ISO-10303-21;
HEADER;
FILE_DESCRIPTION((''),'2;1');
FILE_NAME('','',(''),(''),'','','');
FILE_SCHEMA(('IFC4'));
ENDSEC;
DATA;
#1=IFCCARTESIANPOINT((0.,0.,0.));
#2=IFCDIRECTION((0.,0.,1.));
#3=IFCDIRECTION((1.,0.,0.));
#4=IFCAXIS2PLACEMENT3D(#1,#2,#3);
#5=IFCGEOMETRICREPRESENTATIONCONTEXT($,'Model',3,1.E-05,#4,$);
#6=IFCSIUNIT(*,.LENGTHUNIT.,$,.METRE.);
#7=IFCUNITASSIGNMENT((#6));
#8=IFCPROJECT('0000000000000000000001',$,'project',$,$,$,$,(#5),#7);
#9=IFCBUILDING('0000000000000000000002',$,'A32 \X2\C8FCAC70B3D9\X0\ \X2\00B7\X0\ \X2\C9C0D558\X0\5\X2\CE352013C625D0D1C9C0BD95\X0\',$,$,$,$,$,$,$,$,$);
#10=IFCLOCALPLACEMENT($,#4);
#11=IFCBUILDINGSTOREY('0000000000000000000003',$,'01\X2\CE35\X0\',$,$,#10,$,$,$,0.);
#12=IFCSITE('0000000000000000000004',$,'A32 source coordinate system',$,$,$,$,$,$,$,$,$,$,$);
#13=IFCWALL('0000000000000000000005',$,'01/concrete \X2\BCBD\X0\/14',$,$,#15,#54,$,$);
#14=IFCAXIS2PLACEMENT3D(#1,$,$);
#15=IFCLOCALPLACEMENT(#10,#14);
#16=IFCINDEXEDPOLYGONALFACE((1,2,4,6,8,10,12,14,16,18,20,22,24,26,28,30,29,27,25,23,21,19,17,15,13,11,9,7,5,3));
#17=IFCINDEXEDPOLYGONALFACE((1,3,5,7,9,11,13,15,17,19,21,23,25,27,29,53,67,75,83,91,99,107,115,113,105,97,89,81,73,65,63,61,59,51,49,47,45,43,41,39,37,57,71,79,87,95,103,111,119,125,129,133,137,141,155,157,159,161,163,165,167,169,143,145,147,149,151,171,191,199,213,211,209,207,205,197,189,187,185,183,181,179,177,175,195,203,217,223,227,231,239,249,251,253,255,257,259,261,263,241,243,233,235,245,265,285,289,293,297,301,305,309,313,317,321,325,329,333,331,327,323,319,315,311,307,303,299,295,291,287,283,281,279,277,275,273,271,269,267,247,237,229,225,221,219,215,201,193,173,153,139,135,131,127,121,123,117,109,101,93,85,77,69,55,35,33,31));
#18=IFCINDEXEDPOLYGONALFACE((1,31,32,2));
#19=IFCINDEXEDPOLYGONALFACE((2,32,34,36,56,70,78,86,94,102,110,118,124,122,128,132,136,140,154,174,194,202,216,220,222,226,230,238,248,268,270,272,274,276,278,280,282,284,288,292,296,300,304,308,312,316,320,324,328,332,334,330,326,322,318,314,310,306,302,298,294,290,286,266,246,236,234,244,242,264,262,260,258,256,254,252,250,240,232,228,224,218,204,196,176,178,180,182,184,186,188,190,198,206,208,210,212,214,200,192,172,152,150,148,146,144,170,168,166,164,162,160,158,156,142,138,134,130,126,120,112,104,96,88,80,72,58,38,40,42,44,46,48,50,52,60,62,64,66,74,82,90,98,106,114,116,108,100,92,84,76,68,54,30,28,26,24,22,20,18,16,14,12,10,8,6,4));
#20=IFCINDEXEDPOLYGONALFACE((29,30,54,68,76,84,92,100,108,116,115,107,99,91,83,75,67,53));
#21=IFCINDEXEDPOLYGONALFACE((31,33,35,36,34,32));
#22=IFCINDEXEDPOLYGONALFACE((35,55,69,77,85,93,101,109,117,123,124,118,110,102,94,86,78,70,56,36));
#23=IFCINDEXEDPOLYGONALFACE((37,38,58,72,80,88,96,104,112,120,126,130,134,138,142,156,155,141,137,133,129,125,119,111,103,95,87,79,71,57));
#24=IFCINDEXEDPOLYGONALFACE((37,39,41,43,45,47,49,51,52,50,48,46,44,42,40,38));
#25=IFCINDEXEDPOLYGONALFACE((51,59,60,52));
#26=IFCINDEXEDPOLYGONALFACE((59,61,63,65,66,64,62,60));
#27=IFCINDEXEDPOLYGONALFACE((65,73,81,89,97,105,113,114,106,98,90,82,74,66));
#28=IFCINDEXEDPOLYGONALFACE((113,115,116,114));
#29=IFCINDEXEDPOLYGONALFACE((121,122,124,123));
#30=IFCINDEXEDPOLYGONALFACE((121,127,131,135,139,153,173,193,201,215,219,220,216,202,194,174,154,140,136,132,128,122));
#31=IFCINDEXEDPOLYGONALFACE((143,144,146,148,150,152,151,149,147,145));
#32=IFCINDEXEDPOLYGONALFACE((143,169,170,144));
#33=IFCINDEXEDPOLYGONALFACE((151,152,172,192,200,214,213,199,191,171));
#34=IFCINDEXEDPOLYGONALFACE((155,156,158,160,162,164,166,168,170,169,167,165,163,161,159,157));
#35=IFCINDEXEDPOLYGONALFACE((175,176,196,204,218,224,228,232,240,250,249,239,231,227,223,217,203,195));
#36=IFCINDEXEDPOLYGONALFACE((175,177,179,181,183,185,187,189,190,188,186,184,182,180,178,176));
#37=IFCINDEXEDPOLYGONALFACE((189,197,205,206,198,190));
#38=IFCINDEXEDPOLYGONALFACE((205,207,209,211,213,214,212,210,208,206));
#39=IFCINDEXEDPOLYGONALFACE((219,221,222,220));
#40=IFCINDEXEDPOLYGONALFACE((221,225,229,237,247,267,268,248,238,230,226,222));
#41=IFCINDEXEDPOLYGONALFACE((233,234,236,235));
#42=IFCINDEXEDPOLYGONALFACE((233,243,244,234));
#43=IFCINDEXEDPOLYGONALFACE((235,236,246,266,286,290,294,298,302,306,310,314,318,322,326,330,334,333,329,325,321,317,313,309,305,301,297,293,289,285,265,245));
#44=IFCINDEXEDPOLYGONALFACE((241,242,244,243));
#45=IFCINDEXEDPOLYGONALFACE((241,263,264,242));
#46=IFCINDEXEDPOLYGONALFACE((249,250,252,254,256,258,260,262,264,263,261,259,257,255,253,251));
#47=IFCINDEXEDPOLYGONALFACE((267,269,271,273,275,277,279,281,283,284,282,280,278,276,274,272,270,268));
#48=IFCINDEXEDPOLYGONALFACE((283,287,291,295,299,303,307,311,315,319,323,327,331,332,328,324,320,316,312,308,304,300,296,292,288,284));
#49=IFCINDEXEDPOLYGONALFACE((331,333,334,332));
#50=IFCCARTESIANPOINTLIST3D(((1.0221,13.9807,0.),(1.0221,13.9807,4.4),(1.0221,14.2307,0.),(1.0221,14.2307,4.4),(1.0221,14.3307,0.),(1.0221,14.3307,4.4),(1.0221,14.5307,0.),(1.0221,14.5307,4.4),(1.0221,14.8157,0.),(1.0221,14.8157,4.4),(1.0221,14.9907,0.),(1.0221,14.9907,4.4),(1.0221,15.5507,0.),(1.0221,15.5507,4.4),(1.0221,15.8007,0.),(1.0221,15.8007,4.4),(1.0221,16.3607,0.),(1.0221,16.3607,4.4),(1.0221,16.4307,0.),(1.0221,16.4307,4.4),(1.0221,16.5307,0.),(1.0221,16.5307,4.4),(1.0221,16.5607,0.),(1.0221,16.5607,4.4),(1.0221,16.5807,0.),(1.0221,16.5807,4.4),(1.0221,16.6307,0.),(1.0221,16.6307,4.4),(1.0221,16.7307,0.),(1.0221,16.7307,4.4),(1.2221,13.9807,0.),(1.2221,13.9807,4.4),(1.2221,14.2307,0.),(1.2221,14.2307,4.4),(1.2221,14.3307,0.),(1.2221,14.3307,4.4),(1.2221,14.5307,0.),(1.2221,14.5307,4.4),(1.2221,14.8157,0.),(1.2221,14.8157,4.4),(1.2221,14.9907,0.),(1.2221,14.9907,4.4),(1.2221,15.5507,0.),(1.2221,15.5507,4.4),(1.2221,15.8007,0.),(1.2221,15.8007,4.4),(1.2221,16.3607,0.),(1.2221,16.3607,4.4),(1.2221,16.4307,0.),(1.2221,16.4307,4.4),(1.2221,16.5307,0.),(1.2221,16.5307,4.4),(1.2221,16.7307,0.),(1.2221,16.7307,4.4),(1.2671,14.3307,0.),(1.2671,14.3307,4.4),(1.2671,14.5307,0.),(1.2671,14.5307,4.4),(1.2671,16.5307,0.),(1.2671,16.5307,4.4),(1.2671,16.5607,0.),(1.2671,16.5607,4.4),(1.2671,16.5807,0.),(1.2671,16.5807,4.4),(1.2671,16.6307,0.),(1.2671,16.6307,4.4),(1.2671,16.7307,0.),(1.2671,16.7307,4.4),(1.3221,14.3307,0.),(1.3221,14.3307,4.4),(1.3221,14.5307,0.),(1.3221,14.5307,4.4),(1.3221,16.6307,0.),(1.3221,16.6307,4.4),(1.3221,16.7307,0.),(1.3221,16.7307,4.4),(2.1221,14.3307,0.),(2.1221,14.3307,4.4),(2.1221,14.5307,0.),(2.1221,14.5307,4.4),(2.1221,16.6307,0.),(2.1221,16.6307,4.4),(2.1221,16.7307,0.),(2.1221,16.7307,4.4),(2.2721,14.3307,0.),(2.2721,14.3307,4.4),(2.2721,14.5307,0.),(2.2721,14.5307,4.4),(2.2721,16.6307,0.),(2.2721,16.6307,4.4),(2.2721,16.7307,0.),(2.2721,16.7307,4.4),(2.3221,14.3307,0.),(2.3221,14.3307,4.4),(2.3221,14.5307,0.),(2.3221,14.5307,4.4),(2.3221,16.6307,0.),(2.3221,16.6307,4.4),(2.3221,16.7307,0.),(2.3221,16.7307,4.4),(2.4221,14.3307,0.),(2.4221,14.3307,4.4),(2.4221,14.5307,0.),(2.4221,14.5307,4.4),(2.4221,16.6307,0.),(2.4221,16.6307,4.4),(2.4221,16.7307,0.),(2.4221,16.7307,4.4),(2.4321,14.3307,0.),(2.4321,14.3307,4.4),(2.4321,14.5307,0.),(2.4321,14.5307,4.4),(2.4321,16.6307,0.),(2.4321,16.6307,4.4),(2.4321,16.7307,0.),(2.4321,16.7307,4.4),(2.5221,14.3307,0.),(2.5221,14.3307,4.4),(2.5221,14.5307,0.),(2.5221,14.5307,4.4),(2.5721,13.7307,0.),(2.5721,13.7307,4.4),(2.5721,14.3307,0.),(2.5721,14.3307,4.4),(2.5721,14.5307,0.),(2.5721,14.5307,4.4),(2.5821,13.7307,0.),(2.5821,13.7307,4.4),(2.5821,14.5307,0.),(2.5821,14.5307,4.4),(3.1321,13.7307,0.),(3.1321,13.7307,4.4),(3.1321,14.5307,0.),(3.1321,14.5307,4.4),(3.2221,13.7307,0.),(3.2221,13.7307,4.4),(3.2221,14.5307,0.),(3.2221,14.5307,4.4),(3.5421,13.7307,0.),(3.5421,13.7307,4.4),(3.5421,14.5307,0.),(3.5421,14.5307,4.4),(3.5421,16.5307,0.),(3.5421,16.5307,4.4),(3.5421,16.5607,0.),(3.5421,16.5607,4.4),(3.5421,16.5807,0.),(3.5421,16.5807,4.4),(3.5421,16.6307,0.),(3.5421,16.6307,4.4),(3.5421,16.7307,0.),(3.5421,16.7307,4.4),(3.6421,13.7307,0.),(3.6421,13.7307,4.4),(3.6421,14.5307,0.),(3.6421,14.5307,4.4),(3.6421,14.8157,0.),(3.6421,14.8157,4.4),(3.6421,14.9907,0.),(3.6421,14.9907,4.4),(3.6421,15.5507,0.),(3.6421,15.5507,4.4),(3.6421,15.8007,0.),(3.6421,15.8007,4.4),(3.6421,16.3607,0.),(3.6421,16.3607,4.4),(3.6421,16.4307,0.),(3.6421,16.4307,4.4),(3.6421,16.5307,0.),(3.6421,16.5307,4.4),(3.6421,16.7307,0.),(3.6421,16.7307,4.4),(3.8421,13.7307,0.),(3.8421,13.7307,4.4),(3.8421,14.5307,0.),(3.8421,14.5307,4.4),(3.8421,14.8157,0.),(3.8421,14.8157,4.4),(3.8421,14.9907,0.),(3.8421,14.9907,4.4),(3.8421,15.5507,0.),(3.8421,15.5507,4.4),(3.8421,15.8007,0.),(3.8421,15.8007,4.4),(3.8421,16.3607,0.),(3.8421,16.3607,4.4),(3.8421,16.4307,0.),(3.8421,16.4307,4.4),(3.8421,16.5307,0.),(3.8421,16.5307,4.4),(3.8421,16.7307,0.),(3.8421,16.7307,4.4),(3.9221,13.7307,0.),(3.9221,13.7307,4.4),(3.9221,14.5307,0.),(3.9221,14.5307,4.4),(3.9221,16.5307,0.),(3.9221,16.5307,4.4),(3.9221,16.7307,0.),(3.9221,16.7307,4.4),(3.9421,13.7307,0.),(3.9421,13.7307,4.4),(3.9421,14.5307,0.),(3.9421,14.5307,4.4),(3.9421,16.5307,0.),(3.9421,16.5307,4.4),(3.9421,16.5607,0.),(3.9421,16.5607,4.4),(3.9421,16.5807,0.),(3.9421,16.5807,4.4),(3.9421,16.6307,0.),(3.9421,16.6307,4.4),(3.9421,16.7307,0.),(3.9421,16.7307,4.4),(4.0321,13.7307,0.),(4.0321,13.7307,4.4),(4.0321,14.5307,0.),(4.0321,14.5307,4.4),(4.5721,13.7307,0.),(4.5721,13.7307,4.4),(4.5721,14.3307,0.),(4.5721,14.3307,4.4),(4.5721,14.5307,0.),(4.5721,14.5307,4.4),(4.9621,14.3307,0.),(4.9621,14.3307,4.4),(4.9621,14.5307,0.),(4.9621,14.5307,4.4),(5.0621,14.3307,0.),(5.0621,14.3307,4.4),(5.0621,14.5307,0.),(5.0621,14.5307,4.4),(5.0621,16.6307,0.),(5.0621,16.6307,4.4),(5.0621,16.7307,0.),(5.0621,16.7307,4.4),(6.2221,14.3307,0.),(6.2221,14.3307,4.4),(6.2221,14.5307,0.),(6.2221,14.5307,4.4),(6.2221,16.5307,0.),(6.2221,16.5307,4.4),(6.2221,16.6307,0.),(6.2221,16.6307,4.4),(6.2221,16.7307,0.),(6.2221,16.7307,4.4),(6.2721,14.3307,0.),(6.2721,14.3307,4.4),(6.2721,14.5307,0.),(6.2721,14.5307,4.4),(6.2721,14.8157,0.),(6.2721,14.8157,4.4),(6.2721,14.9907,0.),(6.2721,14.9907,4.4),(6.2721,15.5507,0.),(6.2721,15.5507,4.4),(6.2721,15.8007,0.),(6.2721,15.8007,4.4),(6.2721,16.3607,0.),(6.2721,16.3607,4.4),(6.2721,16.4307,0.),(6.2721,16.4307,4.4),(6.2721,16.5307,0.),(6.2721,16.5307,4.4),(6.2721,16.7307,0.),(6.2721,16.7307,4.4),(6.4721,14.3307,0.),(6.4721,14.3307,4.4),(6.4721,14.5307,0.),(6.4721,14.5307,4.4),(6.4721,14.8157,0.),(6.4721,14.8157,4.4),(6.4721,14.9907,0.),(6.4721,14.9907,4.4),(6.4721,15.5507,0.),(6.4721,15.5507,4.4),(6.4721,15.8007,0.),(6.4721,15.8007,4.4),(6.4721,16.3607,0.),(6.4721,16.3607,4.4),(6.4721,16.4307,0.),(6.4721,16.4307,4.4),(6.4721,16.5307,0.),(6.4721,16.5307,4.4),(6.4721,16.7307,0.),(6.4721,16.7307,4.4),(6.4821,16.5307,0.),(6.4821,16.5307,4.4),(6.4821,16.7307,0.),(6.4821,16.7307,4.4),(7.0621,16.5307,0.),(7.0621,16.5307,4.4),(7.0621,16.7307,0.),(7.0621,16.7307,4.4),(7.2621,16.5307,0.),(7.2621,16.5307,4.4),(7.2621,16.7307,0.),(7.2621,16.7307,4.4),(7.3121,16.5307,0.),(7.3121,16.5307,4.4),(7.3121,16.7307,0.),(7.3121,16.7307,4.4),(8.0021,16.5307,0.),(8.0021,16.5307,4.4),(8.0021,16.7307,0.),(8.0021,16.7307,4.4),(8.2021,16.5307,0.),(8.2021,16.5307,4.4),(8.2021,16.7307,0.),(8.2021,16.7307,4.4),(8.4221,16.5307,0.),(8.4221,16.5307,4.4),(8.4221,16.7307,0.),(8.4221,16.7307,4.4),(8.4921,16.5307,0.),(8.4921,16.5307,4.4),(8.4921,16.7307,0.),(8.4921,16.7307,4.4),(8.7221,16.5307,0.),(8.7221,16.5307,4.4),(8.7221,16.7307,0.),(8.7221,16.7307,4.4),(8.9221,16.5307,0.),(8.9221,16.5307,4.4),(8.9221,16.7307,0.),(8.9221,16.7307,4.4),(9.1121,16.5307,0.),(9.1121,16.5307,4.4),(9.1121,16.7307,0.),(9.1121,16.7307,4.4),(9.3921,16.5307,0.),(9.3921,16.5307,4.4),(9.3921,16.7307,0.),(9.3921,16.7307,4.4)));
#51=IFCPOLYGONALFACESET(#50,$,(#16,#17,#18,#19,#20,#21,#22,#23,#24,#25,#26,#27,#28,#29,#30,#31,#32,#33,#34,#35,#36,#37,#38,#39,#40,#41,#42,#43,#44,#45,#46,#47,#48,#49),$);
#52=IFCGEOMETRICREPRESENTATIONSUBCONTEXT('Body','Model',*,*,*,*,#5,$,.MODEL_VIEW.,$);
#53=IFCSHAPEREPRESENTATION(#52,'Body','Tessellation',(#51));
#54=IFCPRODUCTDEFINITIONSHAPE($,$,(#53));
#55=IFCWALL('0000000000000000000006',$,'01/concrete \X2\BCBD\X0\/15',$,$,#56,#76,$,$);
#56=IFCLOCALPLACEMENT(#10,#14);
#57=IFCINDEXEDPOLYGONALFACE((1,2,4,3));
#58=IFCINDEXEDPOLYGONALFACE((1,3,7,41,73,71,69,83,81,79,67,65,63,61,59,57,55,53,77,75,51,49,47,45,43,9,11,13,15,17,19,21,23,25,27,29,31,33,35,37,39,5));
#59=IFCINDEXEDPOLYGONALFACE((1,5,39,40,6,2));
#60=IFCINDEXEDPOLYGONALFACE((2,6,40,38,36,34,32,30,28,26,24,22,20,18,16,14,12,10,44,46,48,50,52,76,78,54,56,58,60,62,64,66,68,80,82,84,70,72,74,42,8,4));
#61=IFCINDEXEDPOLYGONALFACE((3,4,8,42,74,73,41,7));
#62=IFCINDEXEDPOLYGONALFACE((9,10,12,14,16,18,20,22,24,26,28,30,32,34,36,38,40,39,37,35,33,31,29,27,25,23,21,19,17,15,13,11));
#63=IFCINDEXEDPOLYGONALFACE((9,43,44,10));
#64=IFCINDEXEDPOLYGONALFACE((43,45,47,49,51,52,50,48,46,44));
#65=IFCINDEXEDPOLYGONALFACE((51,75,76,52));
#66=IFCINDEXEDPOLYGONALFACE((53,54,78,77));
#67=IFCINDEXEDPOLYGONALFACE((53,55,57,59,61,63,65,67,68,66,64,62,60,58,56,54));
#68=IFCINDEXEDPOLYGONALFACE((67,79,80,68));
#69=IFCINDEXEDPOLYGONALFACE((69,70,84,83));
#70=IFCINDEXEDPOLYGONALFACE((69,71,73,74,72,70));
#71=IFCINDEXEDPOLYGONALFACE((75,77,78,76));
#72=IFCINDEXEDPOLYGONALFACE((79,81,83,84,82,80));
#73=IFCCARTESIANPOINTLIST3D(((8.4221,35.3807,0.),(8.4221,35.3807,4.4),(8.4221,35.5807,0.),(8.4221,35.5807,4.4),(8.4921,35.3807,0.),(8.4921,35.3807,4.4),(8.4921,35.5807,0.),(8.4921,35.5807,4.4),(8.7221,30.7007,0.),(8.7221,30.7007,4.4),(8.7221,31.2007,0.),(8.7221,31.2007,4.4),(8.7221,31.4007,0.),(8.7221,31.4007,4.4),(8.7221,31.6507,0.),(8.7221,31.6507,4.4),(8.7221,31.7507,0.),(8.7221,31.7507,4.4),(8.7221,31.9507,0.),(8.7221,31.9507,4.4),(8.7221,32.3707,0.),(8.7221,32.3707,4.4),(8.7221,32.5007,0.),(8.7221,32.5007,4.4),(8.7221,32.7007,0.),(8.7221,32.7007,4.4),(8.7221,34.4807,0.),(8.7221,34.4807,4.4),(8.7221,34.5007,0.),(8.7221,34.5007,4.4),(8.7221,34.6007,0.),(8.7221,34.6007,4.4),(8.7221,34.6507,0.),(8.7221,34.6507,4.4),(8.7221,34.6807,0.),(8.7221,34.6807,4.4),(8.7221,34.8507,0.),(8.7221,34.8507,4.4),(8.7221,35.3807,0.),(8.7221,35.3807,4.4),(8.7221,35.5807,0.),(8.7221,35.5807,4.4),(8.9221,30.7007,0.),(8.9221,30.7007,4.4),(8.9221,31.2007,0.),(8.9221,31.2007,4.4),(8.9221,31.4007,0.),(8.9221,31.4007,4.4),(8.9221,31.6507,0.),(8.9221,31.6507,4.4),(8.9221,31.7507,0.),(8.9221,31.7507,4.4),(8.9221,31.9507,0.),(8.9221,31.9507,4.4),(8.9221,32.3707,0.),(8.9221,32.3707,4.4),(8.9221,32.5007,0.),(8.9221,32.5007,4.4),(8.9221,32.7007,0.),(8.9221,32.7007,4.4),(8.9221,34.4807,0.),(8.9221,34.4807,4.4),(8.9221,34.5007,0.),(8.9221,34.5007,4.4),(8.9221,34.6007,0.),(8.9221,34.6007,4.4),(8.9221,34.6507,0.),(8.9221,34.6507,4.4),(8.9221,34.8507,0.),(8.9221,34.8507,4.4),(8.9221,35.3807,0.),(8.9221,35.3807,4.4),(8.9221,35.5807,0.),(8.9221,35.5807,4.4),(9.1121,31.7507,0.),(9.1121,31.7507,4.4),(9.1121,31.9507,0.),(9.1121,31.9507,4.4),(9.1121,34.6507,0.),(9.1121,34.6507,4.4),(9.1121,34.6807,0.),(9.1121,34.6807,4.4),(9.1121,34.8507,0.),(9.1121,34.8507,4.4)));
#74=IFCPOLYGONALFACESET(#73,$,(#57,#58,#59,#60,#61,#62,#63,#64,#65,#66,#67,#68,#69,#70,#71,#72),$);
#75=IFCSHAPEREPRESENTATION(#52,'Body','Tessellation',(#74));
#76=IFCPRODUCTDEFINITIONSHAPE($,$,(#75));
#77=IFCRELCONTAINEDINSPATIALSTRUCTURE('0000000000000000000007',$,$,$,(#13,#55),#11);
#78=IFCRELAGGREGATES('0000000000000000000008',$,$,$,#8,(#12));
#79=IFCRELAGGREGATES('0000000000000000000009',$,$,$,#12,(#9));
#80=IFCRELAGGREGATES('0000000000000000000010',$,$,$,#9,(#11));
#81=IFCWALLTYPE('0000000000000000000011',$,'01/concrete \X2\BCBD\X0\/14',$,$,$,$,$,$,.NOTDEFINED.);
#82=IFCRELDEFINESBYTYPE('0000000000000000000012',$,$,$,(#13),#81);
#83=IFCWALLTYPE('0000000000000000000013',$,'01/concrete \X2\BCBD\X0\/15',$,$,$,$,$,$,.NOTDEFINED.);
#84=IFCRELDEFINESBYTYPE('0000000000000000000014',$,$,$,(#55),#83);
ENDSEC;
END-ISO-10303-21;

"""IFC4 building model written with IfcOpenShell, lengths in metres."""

from ifc_helpers import new_model, si_unit, origin, origin_with_axes, place, context, subcontext, project, spatial, polyline, outline, extrude, source, transform, mapped, type_object, type_shapes, element, save


model = new_model("IFC4")

# Units and contexts
model_context = context("Model", 3, precision=1e-05, world=origin_with_axes())
body_context = subcontext(model_context, "Body", "Model", "MODEL_VIEW")
ifc_project = project(units=[si_unit("LENGTHUNIT", "METRE")], contexts=[model_context])

# Site, building, storey
site = spatial("IfcSite", under=ifc_project, Name="A32 source coordinate system")
building = spatial("IfcBuilding", under=site, Name="A32 주거동 · 지하5층–옥탑지붕")
storey_placement = place(None, origin_with_axes())
storey = spatial("IfcBuildingStorey", under=building, at=storey_placement, Name="01층", Elevation=0.0)

# Walls
wall_type_1 = type_object("IfcWallType", Name="01/concrete 벽/14", PredefinedType="NOTDEFINED")
shared_shape_1 = source(origin(), body_context, "Body", "SweptSolid", [
    extrude(outline(polyline([(1.0221, 14.9907), (1.0221, 15.5507), (1.0221, 15.8007), (1.0221, 16.3607), (1.0221, 16.4307), (1.0221, 16.5307), (1.0221, 16.5607), (1.0221, 16.5807), (1.0221, 16.6307), (1.0221, 16.7307), (1.2221, 16.7307), (1.2671, 16.7307), (1.3221, 16.7307), (2.1221, 16.7307), (2.2721, 16.7307), (2.3221, 16.7307), (2.4221, 16.7307), (2.4321, 16.7307), (2.4321, 16.6307), (2.4221, 16.6307), (2.3221, 16.6307), (2.2721, 16.6307), (2.1221, 16.6307), (1.3221, 16.6307), (1.2671, 16.6307), (1.2671, 16.5807), (1.2671, 16.5607), (1.2671, 16.5307), (1.2221, 16.5307), (1.2221, 16.4307), (1.2221, 16.3607), (1.2221, 15.8007), (1.2221, 15.5507), (1.2221, 14.9907), (1.2221, 14.8157), (1.2221, 14.5307), (1.2671, 14.5307), (1.3221, 14.5307), (2.1221, 14.5307), (2.2721, 14.5307), (2.3221, 14.5307), (2.4221, 14.5307), (2.4321, 14.5307), (2.5221, 14.5307), (2.5721, 14.5307), (2.5821, 14.5307), (3.1321, 14.5307), (3.2221, 14.5307), (3.5421, 14.5307), (3.6421, 14.5307), (3.6421, 14.8157), (3.6421, 14.9907), (3.6421, 15.5507), (3.6421, 15.8007), (3.6421, 16.3607), (3.6421, 16.4307), (3.6421, 16.5307), (3.5421, 16.5307), (3.5421, 16.5607), (3.5421, 16.5807), (3.5421, 16.6307), (3.5421, 16.7307), (3.6421, 16.7307), (3.8421, 16.7307), (3.9221, 16.7307), (3.9421, 16.7307), (3.9421, 16.6307), (3.9421, 16.5807), (3.9421, 16.5607), (3.9421, 16.5307), (3.9221, 16.5307), (3.8421, 16.5307), (3.8421, 16.4307), (3.8421, 16.3607), (3.8421, 15.8007), (3.8421, 15.5507), (3.8421, 14.9907), (3.8421, 14.8157), (3.8421, 14.5307), (3.9221, 14.5307), (3.9421, 14.5307), (4.0321, 14.5307), (4.5721, 14.5307), (4.9621, 14.5307), (5.0621, 14.5307), (6.2221, 14.5307), (6.2721, 14.5307), (6.2721, 14.8157), (6.2721, 14.9907), (6.2721, 15.5507), (6.2721, 15.8007), (6.2721, 16.3607), (6.2721, 16.4307), (6.2721, 16.5307), (6.2221, 16.5307), (6.2221, 16.6307), (5.0621, 16.6307), (5.0621, 16.7307), (6.2221, 16.7307), (6.2721, 16.7307), (6.4721, 16.7307), (6.4821, 16.7307), (7.0621, 16.7307), (7.2621, 16.7307), (7.3121, 16.7307), (8.0021, 16.7307), (8.2021, 16.7307), (8.4221, 16.7307), (8.4921, 16.7307), (8.7221, 16.7307), (8.9221, 16.7307), (9.1121, 16.7307), (9.3921, 16.7307), (9.3921, 16.5307), (9.1121, 16.5307), (8.9221, 16.5307), (8.7221, 16.5307), (8.4921, 16.5307), (8.4221, 16.5307), (8.2021, 16.5307), (8.0021, 16.5307), (7.3121, 16.5307), (7.2621, 16.5307), (7.0621, 16.5307), (6.4821, 16.5307), (6.4721, 16.5307), (6.4721, 16.4307), (6.4721, 16.3607), (6.4721, 15.8007), (6.4721, 15.5507), (6.4721, 14.9907), (6.4721, 14.8157), (6.4721, 14.5307), (6.4721, 14.3307), (6.2721, 14.3307), (6.2221, 14.3307), (5.0621, 14.3307), (4.9621, 14.3307), (4.5721, 14.3307), (4.5721, 13.7307), (4.0321, 13.7307), (3.9421, 13.7307), (3.9221, 13.7307), (3.8421, 13.7307), (3.6421, 13.7307), (3.5421, 13.7307), (3.2221, 13.7307), (3.1321, 13.7307), (2.5821, 13.7307), (2.5721, 13.7307), (2.5721, 14.3307), (2.5221, 14.3307), (2.4321, 14.3307), (2.4221, 14.3307), (2.3221, 14.3307), (2.2721, 14.3307), (2.1221, 14.3307), (1.3221, 14.3307), (1.2671, 14.3307), (1.2221, 14.3307), (1.2221, 14.2307), (1.2221, 13.9807), (1.0221, 13.9807), (1.0221, 14.2307), (1.0221, 14.3307), (1.0221, 14.5307), (1.0221, 14.8157), (1.0221, 14.9907)])), origin(), (0.0, 0.0, 1.0), 4.4),
])
type_shapes(wall_type_1, [shared_shape_1])
wall_1_placement = place(storey_placement, origin_with_axes())
element("IfcWall", 1, at=wall_1_placement, inside=storey, type_object=wall_type_1, Name="01/concrete 벽/14", context=body_context, shape_type="MappedRepresentation", body=[
    mapped(shared_shape_1, transform((0.0, 0.0, 0.0), scale=1.0)),
])
wall_type_2 = type_object("IfcWallType", Name="01/concrete 벽/15", PredefinedType="NOTDEFINED")
shared_shape_2 = source(origin(), body_context, "Body", "SweptSolid", [
    extrude(outline(polyline([(8.7221, 34.6007), (8.7221, 34.6507), (8.7221, 34.6807), (8.7221, 34.8507), (8.7221, 35.3807), (8.4921, 35.3807), (8.4221, 35.3807), (8.4221, 35.5807), (8.4921, 35.5807), (8.7221, 35.5807), (8.9221, 35.5807), (8.9221, 35.3807), (8.9221, 34.8507), (9.1121, 34.8507), (9.1121, 34.6807), (9.1121, 34.6507), (8.9221, 34.6507), (8.9221, 34.6007), (8.9221, 34.5007), (8.9221, 34.4807), (8.9221, 32.7007), (8.9221, 32.5007), (8.9221, 32.3707), (8.9221, 31.9507), (9.1121, 31.9507), (9.1121, 31.7507), (8.9221, 31.7507), (8.9221, 31.6507), (8.9221, 31.4007), (8.9221, 31.2007), (8.9221, 30.7007), (8.7221, 30.7007), (8.7221, 31.2007), (8.7221, 31.4007), (8.7221, 31.6507), (8.7221, 31.7507), (8.7221, 31.9507), (8.7221, 32.3707), (8.7221, 32.5007), (8.7221, 32.7007), (8.7221, 34.4807), (8.7221, 34.5007), (8.7221, 34.6007)])), origin(), (0.0, 0.0, 1.0), 4.4),
])
type_shapes(wall_type_2, [shared_shape_2])
wall_2_placement = place(storey_placement, origin_with_axes())
element("IfcWall", 2, at=wall_2_placement, inside=storey, type_object=wall_type_2, Name="01/concrete 벽/15", context=body_context, shape_type="MappedRepresentation", body=[
    mapped(shared_shape_2, transform((0.0, 0.0, 0.0), scale=1.0)),
])

save(model, "model.ifc")
